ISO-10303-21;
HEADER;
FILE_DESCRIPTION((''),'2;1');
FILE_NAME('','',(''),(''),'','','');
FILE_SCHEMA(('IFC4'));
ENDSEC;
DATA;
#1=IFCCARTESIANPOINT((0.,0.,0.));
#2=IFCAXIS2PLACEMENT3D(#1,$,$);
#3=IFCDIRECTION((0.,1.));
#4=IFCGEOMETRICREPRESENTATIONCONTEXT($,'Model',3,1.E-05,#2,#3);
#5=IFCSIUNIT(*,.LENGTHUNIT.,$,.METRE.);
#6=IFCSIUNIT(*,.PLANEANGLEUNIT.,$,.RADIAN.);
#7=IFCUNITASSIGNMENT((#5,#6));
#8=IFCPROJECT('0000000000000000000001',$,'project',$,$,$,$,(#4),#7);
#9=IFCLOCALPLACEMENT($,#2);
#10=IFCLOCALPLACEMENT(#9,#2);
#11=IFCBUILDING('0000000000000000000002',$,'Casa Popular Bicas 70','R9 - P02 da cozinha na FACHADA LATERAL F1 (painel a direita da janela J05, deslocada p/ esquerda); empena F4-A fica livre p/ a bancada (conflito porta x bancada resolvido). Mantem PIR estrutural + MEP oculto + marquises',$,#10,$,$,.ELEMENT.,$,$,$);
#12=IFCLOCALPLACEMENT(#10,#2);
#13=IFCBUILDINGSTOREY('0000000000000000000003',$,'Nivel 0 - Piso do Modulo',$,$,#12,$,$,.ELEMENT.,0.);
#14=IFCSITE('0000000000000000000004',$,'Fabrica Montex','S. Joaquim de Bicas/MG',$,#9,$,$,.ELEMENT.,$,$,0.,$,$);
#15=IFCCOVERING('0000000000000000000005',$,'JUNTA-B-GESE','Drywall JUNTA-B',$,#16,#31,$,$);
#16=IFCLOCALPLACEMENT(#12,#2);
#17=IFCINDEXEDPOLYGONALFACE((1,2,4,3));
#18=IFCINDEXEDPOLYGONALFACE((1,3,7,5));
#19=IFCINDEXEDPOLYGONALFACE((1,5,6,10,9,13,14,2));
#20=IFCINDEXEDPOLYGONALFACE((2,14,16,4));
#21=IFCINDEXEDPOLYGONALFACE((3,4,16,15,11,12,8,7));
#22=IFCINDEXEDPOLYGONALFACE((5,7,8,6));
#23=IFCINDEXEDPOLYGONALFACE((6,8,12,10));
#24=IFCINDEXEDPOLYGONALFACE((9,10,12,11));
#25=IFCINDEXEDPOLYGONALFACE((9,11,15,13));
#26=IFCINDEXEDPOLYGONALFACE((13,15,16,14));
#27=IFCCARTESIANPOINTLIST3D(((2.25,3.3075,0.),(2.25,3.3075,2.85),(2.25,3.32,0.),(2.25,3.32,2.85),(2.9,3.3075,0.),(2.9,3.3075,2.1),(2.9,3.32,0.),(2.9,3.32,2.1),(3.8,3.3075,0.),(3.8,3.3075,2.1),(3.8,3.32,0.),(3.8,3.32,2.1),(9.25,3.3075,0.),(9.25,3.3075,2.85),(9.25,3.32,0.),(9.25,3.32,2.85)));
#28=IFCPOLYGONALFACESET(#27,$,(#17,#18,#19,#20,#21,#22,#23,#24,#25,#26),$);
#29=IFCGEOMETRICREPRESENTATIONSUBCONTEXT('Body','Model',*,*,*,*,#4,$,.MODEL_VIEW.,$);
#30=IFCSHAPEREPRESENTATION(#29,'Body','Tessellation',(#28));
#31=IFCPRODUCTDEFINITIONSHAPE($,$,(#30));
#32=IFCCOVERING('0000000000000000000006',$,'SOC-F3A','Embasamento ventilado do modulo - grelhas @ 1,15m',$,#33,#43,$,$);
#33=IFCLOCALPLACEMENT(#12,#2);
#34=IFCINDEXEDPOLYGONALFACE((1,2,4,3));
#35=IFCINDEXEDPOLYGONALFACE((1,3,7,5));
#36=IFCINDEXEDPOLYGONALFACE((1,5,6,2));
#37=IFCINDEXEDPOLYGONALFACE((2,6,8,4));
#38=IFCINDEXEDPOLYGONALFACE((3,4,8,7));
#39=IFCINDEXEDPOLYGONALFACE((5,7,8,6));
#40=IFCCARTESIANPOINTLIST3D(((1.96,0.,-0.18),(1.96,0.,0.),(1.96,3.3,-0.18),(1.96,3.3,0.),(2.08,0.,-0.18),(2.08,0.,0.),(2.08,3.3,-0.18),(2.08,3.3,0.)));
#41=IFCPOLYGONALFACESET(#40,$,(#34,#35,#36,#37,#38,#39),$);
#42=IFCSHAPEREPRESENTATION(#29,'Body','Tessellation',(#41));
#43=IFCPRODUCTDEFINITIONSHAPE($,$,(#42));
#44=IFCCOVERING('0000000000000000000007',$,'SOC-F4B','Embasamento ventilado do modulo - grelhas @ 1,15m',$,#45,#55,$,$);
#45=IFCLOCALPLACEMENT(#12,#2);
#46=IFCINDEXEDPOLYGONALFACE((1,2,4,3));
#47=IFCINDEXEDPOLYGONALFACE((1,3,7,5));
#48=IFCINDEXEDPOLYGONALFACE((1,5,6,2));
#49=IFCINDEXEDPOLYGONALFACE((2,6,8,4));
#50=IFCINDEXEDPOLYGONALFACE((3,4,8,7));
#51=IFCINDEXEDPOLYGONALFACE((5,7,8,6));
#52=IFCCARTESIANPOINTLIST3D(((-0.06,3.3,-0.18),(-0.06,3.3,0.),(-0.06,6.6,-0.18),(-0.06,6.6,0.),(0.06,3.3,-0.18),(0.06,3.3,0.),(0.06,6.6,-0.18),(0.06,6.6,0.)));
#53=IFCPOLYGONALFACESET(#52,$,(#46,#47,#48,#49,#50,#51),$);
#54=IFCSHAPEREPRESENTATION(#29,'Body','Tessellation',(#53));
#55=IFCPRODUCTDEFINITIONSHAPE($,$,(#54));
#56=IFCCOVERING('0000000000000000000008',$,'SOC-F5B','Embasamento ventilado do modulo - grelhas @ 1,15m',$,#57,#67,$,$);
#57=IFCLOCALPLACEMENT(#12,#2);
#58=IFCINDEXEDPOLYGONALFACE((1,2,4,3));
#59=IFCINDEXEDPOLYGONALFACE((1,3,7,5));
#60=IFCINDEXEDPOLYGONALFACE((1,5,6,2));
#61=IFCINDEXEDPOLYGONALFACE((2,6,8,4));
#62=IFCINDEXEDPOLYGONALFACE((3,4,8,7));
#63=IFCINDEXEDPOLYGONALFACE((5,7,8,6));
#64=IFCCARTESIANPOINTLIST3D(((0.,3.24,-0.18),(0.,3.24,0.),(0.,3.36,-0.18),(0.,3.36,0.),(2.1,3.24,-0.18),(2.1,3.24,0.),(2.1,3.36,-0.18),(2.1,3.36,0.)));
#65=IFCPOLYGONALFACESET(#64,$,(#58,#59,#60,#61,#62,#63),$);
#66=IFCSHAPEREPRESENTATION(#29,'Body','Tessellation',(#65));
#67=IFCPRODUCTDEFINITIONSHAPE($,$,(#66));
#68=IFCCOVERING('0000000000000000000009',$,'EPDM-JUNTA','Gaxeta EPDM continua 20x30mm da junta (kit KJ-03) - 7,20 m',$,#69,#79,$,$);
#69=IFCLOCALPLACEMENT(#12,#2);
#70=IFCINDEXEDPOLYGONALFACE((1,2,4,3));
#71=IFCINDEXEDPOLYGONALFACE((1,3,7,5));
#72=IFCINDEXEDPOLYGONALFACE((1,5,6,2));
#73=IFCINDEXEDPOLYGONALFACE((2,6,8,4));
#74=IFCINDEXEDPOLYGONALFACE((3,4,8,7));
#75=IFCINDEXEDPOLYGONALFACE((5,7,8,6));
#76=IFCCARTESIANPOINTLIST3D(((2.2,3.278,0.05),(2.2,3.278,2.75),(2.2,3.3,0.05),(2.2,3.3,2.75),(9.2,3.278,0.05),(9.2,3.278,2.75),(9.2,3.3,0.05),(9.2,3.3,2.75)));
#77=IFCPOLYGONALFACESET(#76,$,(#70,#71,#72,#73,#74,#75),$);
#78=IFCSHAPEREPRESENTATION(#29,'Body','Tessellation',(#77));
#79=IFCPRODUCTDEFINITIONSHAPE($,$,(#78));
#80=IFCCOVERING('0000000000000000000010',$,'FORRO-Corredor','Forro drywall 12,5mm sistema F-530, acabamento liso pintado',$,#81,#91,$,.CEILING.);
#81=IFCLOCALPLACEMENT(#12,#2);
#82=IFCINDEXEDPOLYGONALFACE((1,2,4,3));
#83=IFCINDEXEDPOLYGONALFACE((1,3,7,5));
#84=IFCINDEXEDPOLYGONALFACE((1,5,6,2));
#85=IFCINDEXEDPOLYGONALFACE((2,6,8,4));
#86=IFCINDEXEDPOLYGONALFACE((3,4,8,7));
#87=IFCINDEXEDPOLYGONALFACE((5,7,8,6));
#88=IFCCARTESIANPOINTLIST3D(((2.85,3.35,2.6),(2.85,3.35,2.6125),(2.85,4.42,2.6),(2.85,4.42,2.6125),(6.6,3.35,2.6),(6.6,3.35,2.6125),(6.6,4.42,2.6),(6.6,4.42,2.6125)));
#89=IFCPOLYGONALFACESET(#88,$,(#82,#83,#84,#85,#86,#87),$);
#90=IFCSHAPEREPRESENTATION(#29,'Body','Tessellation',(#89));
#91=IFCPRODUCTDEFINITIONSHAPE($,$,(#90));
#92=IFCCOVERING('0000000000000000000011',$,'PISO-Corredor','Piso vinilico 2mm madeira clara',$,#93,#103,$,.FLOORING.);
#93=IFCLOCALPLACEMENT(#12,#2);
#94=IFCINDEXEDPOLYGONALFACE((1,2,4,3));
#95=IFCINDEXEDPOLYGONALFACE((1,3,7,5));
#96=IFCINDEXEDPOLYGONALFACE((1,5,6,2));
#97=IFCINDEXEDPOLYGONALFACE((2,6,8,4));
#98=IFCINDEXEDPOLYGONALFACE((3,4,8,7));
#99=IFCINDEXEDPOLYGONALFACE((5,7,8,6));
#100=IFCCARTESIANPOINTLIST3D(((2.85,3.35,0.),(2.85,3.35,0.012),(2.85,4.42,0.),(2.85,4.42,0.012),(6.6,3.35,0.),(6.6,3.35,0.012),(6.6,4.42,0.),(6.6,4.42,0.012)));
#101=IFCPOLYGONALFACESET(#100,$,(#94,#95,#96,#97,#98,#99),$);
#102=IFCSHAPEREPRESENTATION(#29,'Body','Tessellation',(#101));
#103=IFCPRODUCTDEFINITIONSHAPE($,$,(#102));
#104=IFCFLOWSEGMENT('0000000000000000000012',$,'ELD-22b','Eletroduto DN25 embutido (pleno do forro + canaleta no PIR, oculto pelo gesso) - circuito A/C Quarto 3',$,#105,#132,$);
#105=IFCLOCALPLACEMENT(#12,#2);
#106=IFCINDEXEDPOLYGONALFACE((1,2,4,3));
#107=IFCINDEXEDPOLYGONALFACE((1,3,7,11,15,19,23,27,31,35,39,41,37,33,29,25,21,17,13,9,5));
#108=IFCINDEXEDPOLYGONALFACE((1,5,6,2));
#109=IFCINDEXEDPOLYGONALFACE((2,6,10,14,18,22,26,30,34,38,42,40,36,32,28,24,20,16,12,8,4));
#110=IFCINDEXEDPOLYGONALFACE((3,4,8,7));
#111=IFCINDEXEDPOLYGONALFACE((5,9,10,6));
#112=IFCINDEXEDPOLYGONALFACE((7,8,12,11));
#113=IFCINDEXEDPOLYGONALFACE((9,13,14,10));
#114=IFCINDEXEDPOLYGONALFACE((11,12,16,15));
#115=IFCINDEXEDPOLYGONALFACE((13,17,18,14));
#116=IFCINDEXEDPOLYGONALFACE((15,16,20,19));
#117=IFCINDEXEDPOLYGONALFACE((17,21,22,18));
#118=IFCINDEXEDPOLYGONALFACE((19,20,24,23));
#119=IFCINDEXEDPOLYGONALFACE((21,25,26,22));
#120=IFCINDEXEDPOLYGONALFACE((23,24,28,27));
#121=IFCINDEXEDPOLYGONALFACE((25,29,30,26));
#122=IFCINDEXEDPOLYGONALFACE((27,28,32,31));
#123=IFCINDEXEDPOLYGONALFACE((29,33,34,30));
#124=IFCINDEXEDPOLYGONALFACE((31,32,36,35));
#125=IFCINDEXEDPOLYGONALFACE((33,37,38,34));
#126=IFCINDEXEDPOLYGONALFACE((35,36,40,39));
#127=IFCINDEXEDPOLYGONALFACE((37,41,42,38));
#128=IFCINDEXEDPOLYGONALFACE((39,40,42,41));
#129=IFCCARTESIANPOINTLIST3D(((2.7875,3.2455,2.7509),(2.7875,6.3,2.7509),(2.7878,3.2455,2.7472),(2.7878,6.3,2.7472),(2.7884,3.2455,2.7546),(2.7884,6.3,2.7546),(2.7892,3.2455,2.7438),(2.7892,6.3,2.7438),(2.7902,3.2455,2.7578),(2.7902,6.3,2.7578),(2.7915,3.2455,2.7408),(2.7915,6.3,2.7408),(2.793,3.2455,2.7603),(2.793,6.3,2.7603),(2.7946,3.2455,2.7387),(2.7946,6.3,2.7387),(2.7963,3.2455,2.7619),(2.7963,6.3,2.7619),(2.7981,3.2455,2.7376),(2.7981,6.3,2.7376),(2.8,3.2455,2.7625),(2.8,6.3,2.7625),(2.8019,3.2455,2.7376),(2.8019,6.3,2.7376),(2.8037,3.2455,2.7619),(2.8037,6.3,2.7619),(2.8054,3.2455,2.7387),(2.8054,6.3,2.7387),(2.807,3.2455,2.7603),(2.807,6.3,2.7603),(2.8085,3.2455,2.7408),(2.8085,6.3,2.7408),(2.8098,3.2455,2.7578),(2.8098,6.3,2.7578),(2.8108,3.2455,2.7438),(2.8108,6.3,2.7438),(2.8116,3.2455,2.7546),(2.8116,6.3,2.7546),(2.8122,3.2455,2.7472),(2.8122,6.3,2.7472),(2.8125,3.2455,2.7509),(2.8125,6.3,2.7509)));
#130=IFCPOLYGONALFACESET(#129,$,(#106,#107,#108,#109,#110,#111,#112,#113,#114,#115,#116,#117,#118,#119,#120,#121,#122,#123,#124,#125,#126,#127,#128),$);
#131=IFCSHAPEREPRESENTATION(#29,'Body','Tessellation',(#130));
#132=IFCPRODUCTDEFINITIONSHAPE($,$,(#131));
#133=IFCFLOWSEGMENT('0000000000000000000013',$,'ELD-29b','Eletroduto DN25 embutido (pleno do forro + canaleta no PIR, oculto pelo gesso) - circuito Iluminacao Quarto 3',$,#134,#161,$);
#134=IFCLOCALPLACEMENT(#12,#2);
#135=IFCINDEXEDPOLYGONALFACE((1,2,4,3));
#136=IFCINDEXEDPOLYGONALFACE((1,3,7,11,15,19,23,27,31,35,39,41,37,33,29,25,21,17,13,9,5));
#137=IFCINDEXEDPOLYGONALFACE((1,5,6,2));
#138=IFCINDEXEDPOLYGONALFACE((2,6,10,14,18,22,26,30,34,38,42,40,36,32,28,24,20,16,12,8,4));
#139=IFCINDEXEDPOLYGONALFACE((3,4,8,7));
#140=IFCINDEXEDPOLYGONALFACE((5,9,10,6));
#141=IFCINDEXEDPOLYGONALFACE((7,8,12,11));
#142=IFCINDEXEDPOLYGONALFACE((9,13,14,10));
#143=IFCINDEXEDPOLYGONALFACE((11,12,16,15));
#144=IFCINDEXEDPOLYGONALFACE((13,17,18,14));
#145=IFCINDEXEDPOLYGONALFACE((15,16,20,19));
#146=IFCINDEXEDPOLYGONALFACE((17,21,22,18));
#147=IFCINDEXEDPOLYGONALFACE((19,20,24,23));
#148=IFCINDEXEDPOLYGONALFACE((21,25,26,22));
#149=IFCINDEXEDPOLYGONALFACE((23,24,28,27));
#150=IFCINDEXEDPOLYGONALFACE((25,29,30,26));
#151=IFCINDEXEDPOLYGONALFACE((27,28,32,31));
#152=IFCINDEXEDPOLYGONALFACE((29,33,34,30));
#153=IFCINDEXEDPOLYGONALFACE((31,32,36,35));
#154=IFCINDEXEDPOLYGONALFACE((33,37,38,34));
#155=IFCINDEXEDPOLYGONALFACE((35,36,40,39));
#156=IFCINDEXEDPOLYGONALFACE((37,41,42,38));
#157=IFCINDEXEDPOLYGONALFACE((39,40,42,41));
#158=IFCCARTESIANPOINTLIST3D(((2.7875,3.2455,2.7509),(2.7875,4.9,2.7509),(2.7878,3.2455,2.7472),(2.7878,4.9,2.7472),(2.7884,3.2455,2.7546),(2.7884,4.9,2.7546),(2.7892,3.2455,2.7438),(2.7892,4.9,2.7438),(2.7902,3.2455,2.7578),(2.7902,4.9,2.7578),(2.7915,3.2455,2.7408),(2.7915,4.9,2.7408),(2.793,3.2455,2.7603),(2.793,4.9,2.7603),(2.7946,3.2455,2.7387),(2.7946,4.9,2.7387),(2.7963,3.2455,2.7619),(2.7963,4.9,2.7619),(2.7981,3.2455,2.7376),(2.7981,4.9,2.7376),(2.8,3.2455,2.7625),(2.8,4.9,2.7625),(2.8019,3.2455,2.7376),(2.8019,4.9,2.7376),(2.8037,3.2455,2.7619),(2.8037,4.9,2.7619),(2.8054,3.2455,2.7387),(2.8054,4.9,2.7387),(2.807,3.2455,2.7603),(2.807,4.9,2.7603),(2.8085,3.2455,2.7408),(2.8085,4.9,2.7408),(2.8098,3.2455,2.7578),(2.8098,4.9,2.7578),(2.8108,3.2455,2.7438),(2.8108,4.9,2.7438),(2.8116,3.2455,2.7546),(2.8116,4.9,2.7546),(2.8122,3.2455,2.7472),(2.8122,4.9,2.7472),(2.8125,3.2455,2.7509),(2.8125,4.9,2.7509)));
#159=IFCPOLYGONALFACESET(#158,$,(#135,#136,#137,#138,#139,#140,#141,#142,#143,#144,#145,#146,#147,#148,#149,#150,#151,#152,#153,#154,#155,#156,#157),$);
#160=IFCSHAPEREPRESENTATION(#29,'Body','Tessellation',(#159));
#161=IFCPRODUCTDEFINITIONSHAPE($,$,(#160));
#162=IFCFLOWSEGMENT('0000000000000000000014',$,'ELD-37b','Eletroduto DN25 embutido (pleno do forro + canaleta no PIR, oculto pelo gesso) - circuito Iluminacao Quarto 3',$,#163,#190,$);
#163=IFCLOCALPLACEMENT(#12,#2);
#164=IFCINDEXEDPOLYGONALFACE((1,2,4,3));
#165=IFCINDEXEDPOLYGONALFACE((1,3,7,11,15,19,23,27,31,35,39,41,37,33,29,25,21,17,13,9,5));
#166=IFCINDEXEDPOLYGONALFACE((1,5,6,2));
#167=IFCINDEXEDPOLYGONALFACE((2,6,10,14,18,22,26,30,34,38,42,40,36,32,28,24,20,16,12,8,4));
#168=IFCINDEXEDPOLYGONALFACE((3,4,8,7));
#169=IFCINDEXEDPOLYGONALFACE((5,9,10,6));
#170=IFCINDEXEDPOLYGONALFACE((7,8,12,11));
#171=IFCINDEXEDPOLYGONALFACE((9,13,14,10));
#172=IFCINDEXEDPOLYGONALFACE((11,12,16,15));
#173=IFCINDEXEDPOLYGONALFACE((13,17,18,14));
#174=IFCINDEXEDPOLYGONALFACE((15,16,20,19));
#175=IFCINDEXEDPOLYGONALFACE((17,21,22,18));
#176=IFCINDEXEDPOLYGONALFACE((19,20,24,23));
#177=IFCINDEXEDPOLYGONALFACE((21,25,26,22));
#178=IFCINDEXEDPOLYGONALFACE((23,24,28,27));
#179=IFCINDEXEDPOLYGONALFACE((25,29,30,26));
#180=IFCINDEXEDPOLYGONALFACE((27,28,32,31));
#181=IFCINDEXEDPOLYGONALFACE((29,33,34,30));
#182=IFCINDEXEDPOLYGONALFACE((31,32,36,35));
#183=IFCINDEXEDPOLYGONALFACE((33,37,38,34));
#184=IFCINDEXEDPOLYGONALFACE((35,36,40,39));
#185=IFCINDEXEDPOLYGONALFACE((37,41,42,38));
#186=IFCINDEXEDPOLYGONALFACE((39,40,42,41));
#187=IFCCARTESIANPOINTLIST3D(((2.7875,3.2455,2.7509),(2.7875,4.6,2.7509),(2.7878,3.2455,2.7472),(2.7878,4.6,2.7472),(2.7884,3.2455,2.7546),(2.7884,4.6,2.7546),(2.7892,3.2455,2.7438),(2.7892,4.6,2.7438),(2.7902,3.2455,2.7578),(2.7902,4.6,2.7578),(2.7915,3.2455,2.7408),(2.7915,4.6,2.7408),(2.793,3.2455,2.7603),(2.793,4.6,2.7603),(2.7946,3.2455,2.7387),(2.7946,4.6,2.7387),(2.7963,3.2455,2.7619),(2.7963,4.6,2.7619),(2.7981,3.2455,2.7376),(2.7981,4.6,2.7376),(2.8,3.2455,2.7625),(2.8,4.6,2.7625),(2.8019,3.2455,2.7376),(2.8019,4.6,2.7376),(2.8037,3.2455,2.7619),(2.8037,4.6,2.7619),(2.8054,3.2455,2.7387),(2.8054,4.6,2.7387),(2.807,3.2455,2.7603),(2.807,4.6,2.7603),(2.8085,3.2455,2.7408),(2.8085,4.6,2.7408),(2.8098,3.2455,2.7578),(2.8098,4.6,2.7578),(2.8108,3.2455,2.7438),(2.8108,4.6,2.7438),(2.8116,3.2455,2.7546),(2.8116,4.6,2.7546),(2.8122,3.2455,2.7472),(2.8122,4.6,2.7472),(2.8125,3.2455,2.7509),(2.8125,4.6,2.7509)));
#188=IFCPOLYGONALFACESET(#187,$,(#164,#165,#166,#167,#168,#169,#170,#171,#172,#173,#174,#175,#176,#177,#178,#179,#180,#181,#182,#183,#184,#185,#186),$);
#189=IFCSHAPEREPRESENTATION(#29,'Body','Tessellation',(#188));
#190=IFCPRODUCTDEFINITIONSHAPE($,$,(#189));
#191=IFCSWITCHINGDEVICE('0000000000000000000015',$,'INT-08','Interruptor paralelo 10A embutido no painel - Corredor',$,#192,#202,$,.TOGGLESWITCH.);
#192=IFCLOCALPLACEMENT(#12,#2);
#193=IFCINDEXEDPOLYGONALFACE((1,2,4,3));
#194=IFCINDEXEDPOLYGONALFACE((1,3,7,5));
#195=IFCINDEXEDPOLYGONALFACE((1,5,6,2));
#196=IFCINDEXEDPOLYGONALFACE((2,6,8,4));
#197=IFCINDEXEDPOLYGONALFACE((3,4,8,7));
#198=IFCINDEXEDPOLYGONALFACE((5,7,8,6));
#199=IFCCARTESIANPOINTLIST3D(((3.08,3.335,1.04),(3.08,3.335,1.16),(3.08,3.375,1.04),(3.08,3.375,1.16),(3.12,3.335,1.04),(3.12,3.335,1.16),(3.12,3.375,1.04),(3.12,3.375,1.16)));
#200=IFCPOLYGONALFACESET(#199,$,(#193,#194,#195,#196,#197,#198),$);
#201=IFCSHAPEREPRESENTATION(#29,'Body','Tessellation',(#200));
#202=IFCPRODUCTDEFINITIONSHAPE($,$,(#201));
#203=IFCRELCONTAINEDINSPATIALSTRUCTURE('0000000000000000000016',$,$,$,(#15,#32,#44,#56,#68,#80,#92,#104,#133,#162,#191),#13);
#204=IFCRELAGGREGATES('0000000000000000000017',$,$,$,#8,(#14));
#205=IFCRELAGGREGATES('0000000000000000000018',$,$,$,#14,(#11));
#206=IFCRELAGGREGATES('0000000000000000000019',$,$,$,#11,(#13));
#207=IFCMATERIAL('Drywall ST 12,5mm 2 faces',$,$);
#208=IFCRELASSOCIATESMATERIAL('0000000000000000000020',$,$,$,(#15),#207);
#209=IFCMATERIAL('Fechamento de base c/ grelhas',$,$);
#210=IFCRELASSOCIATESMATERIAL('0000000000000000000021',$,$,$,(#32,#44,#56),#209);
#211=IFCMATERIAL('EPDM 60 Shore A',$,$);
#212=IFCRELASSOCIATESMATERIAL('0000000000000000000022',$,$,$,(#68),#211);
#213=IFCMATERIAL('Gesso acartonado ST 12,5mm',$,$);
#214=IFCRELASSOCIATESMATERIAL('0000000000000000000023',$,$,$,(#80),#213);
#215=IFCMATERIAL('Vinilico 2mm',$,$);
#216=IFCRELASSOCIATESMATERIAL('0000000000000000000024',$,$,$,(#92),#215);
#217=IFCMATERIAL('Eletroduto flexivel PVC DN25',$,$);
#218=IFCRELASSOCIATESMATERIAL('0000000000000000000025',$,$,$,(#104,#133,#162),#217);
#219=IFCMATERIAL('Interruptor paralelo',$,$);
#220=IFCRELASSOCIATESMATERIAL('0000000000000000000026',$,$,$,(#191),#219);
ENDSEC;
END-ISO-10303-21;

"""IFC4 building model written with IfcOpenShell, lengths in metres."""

from ifc_helpers import new_model, si_unit, direction, frame, frame_2d, origin, origin_2d, place, context, subcontext, project, spatial, rectangle, circle, extrude, material, element, save


model = new_model("IFC4")

# Units and contexts
model_context = context("Model", 3, precision=1e-05, world=origin(), true_north=direction((0.0, 1.0)))
body_context = subcontext(model_context, "Body", "Model", "MODEL_VIEW")
ifc_project = project(units=[si_unit("LENGTHUNIT", "METRE"), si_unit("PLANEANGLEUNIT", "RADIAN")], contexts=[model_context])

# Site, building, storey
site_placement = place(None, origin())
site = spatial("IfcSite", under=ifc_project, at=site_placement, Name="Fabrica Montex", Description="S. Joaquim de Bicas/MG", CompositionType="ELEMENT", RefElevation=0.0)
building_placement = place(site_placement, origin())
building = spatial("IfcBuilding", under=site, at=building_placement, Name="Casa Popular Bicas 70", Description="R9 - P02 da cozinha na FACHADA LATERAL F1 (painel a direita da janela J05, deslocada p/ esquerda); empena F4-A fica livre p/ a bancada (conflito porta x bancada resolvido). Mantem PIR estrutural + MEP oculto + marquises", CompositionType="ELEMENT")
storey_placement = place(building_placement, origin())
storey = spatial("IfcBuildingStorey", under=building, at=storey_placement, Name="Nivel 0 - Piso do Modulo", CompositionType="ELEMENT", Elevation=0.0)

# Covering, opening
ifc_material_1 = material(Name="Drywall ST 12,5mm 2 faces")
covering_1_placement = place(storey_placement, frame((2.25, 3.3137, 0.0), x_axis=(1.0, 0.0, 0.0)))
covering_1 = element("IfcCovering", 1, at=covering_1_placement, inside=storey, material=ifc_material_1, Name="JUNTA-B-GESE", Description="Drywall JUNTA-B", context=body_context, shape_type="SweptSolid", body=[
    extrude(rectangle(XDim=7.0, YDim=0.0125, at=frame_2d((3.5, 0.0))), origin(), (0.0, 0.0, 1.0), 2.85),
])
opening_1_placement = place(storey_placement, frame((3.35, 3.3137, 0.0)))
element("IfcOpeningElement", 2, at=opening_1_placement, cuts=covering_1, PredefinedType="OPENING", context=body_context, shape_type="SweptSolid", body=[
    extrude(rectangle(XDim=0.9, YDim=0.0425, at=origin_2d()), origin(), (0.0, 0.0, 1.0), 2.1),
])

# Coverings
ifc_material_2 = material(Name="Fechamento de base c/ grelhas")
covering_2_placement = place(None, frame((2.02, 3.3, -0.18), z_axis=(0.0, 0.0, 1.0), x_axis=(0.0, -1.0, 0.0)))
element("IfcCovering", 3, at=covering_2_placement, inside=storey, material=ifc_material_2, Name="SOC-F3A", Description="Embasamento ventilado do modulo - grelhas @ 1,15m", context=body_context, shape_type="SweptSolid", body=[
    extrude(rectangle(XDim=3.3, YDim=0.12, at=frame_2d((1.65, 0.0))), origin(), (0.0, 0.0, 1.0), 0.18),
])
covering_3_placement = place(storey_placement, frame((0.0, 3.3, -0.18), x_axis=(0.0, 1.0, 0.0)))
element("IfcCovering", 4, at=covering_3_placement, inside=storey, material=ifc_material_2, Name="SOC-F4B", Description="Embasamento ventilado do modulo - grelhas @ 1,15m", context=body_context, shape_type="SweptSolid", body=[
    extrude(rectangle(XDim=3.3, YDim=0.12, at=frame_2d((1.65, 0.0))), origin(), (0.0, 0.0, 1.0), 0.18),
])
covering_4_placement = place(storey_placement, frame((0.0, 3.3, -0.18), x_axis=(1.0, 0.0, 0.0)))
element("IfcCovering", 5, at=covering_4_placement, inside=storey, material=ifc_material_2, Name="SOC-F5B", Description="Embasamento ventilado do modulo - grelhas @ 1,15m", context=body_context, shape_type="SweptSolid", body=[
    extrude(rectangle(XDim=2.1, YDim=0.12, at=frame_2d((1.05, 0.0))), origin(), (0.0, 0.0, 1.0), 0.18),
])
ifc_material_3 = material(Name="EPDM 60 Shore A")
covering_5_placement = place(storey_placement, frame((2.2, 3.289, 0.05), x_axis=(1.0, 0.0, 0.0)))
element("IfcCovering", 6, at=covering_5_placement, inside=storey, material=ifc_material_3, Name="EPDM-JUNTA", Description="Gaxeta EPDM continua 20x30mm da junta (kit KJ-03) - 7,20 m", context=body_context, shape_type="SweptSolid", body=[
    extrude(rectangle(XDim=7.0, YDim=0.022, at=frame_2d((3.5, 0.0))), origin(), (0.0, 0.0, 1.0), 2.7),
])
ifc_material_4 = material(Name="Gesso acartonado ST 12,5mm")
covering_6_placement = place(storey_placement, frame((2.85, 3.35, 2.6)))
element("IfcCovering", 7, at=covering_6_placement, inside=storey, material=ifc_material_4, Name="FORRO-Corredor", Description="Forro drywall 12,5mm sistema F-530, acabamento liso pintado", PredefinedType="CEILING", context=body_context, shape_type="SweptSolid", body=[
    extrude(rectangle(XDim=3.75, YDim=1.07, at=frame_2d((1.875, 0.535))), origin(), (0.0, 0.0, 1.0), 0.0125),
])
ifc_material_5 = material(Name="Vinilico 2mm")
covering_7_placement = place(storey_placement, frame((2.85, 3.35, 0.0)))
element("IfcCovering", 8, at=covering_7_placement, inside=storey, material=ifc_material_5, Name="PISO-Corredor", Description="Piso vinilico 2mm madeira clara", PredefinedType="FLOORING", context=body_context, shape_type="SweptSolid", body=[
    extrude(rectangle(XDim=3.75, YDim=1.07, at=frame_2d((1.875, 0.535))), origin(), (0.0, 0.0, 1.0), 0.012),
])

# Flow segments
ifc_material_6 = material(Name="Eletroduto flexivel PVC DN25")
flow_segment_1_placement = place(storey_placement, frame((2.8, 3.2455, 2.75), z_axis=(0.0, 1.0, 0.0), x_axis=(0.0, 0.0, 1.0)))
element("IfcFlowSegment", 9, at=flow_segment_1_placement, inside=storey, material=ifc_material_6, Name="ELD-22b", Description="Eletroduto DN25 embutido (pleno do forro + canaleta no PIR, oculto pelo gesso) - circuito A/C Quarto 3", context=body_context, shape_type="SweptSolid", body=[
    extrude(circle(Radius=0.0125, at=origin_2d()), origin(), (0.0, 0.0, 1.0), 3.0545),
])
flow_segment_2_placement = place(storey_placement, frame((2.8, 3.2455, 2.75), z_axis=(0.0, 1.0, 0.0), x_axis=(0.0, 0.0, 1.0)))
element("IfcFlowSegment", 10, at=flow_segment_2_placement, inside=storey, material=ifc_material_6, Name="ELD-29b", Description="Eletroduto DN25 embutido (pleno do forro + canaleta no PIR, oculto pelo gesso) - circuito Iluminacao Quarto 3", context=body_context, shape_type="SweptSolid", body=[
    extrude(circle(Radius=0.0125, at=origin_2d()), origin(), (0.0, 0.0, 1.0), 1.6545),
])
flow_segment_3_placement = place(storey_placement, frame((2.8, 3.2455, 2.75), z_axis=(0.0, 1.0, 0.0), x_axis=(0.0, 0.0, 1.0)))
element("IfcFlowSegment", 11, at=flow_segment_3_placement, inside=storey, material=ifc_material_6, Name="ELD-37b", Description="Eletroduto DN25 embutido (pleno do forro + canaleta no PIR, oculto pelo gesso) - circuito Iluminacao Quarto 3", context=body_context, shape_type="SweptSolid", body=[
    extrude(circle(Radius=0.0125, at=origin_2d()), origin(), (0.0, 0.0, 1.0), 1.3545),
])

# Switching device
ifc_material_7 = material(Name="Interruptor paralelo")
switching_device_placement = place(storey_placement, frame((3.08, 3.335, 1.04)))
element("IfcSwitchingDevice", 12, at=switching_device_placement, inside=storey, material=ifc_material_7, Name="INT-08", Description="Interruptor paralelo 10A embutido no painel - Corredor", PredefinedType="TOGGLESWITCH", context=body_context, shape_type="SweptSolid", body=[
    extrude(rectangle(XDim=0.04, YDim=0.04, at=frame_2d((0.02, 0.02))), origin(), (0.0, 0.0, 1.0), 0.12),
])

save(model, "model.ifc")
